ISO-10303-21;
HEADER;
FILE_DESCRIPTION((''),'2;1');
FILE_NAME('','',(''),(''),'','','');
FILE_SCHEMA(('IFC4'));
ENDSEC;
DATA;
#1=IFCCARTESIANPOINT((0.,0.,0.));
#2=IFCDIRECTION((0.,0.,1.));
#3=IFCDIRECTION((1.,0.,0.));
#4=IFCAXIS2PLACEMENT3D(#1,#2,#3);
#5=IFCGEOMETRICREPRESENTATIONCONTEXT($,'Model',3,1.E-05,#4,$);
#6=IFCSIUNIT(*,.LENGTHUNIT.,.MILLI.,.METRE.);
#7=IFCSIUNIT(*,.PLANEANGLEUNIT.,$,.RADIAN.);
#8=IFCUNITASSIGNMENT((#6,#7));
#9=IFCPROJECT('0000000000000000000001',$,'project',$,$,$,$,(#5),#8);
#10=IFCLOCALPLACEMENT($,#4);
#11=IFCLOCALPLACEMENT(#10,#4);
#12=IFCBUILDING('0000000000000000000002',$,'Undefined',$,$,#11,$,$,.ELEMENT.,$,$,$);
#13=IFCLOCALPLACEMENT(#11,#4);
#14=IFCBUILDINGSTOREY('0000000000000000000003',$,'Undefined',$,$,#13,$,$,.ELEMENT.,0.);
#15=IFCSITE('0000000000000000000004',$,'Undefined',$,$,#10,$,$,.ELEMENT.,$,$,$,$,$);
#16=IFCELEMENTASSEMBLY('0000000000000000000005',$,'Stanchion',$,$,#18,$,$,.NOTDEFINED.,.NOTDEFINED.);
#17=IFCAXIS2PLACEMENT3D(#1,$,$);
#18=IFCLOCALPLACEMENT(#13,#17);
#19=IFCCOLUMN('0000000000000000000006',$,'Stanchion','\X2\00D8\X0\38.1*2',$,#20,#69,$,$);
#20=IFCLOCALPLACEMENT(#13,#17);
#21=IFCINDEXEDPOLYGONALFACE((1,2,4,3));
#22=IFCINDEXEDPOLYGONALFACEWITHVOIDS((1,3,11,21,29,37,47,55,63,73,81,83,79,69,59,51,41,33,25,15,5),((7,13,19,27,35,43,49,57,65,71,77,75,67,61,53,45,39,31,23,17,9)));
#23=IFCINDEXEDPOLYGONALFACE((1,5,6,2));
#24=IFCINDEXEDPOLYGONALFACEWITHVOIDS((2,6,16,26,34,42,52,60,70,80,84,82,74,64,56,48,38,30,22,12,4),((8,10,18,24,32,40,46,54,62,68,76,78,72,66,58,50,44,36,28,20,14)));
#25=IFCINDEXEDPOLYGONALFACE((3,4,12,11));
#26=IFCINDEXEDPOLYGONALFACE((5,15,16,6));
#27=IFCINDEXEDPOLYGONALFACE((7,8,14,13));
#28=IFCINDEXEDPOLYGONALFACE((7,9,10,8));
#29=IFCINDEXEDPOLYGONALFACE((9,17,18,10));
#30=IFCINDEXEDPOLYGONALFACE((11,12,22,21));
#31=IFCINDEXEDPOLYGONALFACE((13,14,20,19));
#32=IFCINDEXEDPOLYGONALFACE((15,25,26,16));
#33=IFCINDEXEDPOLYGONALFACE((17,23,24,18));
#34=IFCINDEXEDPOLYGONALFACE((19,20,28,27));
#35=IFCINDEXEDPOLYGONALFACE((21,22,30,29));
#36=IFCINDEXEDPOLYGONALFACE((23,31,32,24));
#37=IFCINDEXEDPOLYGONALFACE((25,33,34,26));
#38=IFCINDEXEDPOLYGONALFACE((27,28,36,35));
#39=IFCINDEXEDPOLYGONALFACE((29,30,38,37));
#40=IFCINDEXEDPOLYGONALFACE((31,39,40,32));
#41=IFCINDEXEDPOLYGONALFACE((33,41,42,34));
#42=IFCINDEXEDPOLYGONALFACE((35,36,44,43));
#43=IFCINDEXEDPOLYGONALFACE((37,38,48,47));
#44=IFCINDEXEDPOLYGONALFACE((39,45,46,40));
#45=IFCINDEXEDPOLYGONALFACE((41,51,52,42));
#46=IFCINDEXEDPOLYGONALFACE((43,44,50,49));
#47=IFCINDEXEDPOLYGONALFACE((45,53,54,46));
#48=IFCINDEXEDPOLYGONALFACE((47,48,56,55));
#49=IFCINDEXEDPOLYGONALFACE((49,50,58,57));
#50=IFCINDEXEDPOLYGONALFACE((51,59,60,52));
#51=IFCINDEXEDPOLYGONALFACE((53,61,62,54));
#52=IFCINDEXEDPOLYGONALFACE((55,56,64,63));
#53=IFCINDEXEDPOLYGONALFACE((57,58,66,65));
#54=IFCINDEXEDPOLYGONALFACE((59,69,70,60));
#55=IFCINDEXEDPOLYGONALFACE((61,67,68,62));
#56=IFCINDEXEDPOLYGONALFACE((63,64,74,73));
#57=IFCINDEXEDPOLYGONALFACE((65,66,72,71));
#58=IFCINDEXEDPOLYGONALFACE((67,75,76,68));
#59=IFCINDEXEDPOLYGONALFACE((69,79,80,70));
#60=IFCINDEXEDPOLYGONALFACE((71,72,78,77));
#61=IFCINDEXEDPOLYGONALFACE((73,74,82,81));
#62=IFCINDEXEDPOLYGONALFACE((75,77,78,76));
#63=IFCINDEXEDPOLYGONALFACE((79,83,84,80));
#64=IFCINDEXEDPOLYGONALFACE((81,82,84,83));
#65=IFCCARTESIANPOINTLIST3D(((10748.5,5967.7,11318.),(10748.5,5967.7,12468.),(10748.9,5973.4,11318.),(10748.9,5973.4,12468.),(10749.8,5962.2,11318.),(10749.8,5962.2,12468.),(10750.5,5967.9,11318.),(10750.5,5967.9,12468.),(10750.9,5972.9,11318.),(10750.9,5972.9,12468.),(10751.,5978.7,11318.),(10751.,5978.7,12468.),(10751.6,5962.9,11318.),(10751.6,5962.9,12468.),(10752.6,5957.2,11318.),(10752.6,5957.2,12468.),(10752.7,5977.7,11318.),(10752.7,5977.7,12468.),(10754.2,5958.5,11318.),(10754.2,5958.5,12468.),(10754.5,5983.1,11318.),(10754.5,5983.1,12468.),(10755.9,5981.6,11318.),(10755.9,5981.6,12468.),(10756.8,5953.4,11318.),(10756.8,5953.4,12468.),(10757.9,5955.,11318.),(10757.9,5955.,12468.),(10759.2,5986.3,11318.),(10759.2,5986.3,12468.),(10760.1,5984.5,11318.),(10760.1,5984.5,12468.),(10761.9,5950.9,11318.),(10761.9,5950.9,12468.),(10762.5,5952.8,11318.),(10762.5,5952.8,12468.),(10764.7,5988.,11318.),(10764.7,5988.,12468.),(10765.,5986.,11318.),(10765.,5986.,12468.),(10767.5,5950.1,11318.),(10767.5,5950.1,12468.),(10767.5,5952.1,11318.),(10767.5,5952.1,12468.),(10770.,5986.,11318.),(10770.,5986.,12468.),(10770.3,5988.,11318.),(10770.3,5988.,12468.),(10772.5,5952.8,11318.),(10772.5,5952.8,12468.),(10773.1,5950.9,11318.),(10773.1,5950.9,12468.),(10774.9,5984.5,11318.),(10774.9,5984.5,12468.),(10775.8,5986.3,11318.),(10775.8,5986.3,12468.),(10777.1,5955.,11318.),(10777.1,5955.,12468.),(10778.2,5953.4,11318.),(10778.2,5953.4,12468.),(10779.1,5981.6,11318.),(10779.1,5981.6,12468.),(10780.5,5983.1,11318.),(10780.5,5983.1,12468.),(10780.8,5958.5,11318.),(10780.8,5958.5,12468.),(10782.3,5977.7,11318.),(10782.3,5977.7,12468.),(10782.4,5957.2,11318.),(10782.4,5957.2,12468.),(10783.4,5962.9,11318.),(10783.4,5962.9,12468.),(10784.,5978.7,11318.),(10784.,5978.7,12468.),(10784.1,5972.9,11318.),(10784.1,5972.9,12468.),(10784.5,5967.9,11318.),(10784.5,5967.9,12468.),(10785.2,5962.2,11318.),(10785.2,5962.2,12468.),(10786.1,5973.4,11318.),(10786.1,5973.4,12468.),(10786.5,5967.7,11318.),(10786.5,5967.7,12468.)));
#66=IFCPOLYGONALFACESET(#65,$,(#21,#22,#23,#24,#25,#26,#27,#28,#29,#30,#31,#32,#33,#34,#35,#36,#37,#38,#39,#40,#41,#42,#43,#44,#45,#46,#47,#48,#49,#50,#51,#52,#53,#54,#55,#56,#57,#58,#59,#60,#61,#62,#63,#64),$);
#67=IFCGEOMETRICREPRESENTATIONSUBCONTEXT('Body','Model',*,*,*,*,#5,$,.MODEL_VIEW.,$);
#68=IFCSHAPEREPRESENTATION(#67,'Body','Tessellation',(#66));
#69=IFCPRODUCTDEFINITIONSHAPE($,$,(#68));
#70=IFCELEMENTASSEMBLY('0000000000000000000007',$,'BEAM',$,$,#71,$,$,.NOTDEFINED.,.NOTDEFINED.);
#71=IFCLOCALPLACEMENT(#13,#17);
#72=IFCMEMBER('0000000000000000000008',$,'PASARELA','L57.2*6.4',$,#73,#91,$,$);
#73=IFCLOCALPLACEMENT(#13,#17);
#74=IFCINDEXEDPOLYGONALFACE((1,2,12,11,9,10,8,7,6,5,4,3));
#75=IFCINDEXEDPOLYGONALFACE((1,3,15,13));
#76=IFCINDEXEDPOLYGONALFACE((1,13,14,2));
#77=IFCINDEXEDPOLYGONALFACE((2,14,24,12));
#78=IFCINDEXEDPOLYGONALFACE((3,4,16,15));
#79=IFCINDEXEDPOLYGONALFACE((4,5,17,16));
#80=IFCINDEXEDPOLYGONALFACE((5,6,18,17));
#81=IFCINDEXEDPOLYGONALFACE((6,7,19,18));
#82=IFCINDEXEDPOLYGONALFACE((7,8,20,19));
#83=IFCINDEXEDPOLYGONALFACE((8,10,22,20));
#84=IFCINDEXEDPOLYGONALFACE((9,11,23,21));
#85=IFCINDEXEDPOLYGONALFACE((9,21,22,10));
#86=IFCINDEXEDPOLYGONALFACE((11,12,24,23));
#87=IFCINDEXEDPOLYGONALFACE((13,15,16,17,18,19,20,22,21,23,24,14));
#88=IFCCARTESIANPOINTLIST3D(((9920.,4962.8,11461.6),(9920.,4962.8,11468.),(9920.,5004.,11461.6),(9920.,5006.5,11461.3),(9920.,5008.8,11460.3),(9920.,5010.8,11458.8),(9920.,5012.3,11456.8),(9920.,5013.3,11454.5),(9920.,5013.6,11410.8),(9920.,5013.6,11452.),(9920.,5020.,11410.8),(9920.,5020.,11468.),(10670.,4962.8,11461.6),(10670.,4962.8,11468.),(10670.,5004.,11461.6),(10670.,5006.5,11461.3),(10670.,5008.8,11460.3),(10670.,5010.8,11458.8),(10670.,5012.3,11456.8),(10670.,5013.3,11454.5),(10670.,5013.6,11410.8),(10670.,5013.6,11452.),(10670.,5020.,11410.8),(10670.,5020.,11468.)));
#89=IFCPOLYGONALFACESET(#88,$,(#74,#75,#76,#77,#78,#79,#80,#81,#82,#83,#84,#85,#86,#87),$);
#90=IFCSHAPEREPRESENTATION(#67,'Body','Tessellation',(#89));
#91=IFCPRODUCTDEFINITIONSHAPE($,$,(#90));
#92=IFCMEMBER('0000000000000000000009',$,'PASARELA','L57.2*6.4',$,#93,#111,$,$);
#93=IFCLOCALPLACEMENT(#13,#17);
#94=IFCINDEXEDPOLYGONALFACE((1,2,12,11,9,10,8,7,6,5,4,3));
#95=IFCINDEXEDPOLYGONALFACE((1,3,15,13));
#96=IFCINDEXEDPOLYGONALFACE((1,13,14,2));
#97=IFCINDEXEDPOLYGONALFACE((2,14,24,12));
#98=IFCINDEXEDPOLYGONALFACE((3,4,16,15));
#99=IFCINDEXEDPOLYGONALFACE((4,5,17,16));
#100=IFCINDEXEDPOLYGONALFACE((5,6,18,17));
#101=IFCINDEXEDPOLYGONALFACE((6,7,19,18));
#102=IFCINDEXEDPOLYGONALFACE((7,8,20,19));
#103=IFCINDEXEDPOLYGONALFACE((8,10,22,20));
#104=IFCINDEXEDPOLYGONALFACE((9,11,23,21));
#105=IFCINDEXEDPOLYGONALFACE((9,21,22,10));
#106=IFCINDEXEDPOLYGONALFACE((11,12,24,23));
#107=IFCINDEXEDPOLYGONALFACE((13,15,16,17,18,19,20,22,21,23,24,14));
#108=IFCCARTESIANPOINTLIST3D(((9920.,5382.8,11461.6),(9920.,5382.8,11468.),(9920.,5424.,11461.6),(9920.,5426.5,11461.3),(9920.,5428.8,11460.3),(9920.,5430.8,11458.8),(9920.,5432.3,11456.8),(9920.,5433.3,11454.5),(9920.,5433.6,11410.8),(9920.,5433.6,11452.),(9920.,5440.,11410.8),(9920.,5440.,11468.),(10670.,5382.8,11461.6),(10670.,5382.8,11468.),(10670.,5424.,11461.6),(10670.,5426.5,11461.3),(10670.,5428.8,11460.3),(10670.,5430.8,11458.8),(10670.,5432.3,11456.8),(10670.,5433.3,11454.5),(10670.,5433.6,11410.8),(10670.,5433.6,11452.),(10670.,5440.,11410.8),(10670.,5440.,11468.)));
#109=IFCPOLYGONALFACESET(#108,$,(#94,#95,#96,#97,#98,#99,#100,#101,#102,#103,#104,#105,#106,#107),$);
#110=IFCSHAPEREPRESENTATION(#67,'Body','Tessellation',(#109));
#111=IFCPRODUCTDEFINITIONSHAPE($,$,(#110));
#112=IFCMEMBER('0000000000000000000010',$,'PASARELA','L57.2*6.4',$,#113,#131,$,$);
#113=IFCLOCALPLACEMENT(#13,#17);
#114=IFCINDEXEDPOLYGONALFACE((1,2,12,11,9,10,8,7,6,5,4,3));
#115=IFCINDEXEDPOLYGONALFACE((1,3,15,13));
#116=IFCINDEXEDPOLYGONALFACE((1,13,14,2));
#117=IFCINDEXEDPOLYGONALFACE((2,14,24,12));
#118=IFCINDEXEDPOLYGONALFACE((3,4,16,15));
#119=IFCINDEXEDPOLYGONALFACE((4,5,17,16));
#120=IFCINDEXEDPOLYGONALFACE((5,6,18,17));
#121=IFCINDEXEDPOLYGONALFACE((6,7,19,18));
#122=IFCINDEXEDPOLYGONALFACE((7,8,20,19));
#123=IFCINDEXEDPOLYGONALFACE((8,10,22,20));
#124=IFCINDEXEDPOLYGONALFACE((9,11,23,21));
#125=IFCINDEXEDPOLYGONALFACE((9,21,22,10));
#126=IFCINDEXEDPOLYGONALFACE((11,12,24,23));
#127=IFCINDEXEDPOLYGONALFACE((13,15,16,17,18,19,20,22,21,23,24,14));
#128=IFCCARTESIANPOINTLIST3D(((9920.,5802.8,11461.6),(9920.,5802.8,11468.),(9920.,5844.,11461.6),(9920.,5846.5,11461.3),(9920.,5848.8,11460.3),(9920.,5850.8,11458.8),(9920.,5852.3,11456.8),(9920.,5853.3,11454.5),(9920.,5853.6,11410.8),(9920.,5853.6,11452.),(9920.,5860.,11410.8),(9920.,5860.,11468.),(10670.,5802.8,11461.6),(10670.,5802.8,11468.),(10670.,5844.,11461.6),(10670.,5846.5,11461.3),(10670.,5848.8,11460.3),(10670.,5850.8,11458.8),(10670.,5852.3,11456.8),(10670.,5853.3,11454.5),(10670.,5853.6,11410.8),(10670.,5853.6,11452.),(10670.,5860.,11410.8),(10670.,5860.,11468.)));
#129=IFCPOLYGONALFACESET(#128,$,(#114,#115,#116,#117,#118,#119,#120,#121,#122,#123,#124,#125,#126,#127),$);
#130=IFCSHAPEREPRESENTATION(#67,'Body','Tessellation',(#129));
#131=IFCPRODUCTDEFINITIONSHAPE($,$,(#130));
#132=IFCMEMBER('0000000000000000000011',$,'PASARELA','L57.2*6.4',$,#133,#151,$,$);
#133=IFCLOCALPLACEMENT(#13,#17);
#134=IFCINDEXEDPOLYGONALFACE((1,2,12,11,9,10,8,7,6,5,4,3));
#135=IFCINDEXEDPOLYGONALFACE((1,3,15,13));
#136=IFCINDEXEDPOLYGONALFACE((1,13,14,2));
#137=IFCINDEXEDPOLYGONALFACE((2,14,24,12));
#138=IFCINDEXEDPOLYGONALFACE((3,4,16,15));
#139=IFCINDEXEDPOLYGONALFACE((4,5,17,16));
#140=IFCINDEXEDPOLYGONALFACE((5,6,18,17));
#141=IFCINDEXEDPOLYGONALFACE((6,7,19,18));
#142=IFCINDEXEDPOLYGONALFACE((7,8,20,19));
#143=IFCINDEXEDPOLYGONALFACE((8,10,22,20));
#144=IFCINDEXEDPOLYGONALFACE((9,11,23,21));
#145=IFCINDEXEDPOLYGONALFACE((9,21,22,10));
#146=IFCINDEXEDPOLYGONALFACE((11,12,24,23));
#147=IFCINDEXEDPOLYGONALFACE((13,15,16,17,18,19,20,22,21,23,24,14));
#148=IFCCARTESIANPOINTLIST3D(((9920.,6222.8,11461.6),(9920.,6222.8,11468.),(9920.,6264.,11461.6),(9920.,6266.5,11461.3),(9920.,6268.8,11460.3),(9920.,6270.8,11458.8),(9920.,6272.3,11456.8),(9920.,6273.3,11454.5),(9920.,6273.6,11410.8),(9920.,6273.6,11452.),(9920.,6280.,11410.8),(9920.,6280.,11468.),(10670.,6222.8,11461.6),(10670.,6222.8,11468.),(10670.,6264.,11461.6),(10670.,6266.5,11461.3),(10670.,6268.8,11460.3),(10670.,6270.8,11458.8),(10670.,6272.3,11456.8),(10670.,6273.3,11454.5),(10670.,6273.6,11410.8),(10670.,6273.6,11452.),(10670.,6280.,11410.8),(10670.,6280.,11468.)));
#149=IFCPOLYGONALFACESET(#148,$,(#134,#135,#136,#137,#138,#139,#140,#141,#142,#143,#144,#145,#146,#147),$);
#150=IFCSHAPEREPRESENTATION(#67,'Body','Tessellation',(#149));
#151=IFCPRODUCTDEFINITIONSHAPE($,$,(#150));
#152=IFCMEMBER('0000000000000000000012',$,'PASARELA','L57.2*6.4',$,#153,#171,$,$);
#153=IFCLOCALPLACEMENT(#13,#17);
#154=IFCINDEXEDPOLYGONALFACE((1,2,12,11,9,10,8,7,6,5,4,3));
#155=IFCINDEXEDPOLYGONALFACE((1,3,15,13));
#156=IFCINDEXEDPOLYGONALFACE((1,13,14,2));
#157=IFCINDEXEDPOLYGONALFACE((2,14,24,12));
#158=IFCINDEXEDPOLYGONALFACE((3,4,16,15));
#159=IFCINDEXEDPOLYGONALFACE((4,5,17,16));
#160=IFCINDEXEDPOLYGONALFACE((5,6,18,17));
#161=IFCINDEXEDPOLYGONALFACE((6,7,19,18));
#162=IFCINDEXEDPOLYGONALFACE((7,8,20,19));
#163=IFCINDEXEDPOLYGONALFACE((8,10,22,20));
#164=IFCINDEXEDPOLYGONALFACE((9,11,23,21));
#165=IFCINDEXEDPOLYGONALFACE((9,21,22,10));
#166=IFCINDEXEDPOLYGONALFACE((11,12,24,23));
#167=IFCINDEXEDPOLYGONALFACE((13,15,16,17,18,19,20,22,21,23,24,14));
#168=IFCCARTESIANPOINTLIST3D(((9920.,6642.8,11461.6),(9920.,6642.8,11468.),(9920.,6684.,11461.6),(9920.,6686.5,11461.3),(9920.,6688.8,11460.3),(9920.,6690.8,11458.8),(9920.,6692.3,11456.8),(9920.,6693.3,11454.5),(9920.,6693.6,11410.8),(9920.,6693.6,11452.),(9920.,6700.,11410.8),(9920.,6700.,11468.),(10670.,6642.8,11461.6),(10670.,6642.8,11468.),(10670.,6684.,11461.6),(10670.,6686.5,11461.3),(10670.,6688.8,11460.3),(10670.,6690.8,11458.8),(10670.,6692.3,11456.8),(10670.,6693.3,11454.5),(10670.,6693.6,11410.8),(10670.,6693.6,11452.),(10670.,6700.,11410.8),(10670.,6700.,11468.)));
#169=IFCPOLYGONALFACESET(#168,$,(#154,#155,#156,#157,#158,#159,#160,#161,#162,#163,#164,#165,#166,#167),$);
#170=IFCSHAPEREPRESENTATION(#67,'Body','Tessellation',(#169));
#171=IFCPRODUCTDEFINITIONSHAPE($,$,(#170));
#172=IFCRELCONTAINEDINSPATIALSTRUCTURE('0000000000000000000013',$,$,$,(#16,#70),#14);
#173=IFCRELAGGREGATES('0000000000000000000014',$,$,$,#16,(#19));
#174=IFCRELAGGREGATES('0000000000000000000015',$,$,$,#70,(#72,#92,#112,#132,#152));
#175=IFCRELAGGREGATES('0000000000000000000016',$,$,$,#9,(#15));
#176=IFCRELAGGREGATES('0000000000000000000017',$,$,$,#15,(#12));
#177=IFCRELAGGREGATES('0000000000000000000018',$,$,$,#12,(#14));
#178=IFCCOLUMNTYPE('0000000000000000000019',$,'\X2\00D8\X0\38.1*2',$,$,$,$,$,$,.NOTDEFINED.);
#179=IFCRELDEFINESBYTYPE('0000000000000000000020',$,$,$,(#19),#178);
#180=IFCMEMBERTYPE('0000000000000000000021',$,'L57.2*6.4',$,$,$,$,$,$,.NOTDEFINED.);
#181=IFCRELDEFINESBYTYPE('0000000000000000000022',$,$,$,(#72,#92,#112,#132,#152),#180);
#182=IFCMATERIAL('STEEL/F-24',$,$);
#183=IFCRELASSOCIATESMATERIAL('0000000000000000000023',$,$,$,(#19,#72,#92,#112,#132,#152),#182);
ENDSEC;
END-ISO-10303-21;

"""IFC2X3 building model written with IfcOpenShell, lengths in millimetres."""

from ifc_helpers import new_model, si_unit, frame, origin_with_axes, origin_2d_with_axis, place, context, subcontext, project, spatial, hollow_circle, l_section, extrude, material, type_object, element, aggregate, save


model = new_model("IFC2X3")

# Units and contexts
model_context = context("Model", 3, precision=1e-05, world=origin_with_axes())
body_context = subcontext(model_context, "Body", "Model", "MODEL_VIEW")
ifc_project = project(units=[si_unit("LENGTHUNIT", "METRE", prefix="MILLI"), si_unit("PLANEANGLEUNIT", "RADIAN")], contexts=[model_context])

# Site, building, storey
site_placement = place(None, origin_with_axes())
site = spatial("IfcSite", under=ifc_project, at=site_placement, Name="Undefined", CompositionType="ELEMENT")
building_placement = place(site_placement, origin_with_axes())
building = spatial("IfcBuilding", under=site, at=building_placement, Name="Undefined", CompositionType="ELEMENT")
storey_placement = place(building_placement, origin_with_axes())
storey = spatial("IfcBuildingStorey", under=building, at=storey_placement, Name="Undefined", CompositionType="ELEMENT", Elevation=0.0)

# Element assembly, column
ifc_material_1 = material(Name="STEEL/F-24")
column_type = type_object("IfcColumnType", Name="Ø38.1*2", PredefinedType="NOTDEFINED")
assembly_1_placement = place(storey_placement, origin_with_axes())
assembly_1 = element("IfcElementAssembly", 1, at=assembly_1_placement, inside=storey, Name="Stanchion", AssemblyPlace="NOTDEFINED", PredefinedType="NOTDEFINED")
column_1_placement = place(assembly_1_placement, frame((10767.5, 5969.1, 11318.0), z_axis=(0.0, 0.0, 1.0), x_axis=(-1.0, 0.0, 0.0)))
column_1 = element("IfcColumn", 2, at=column_1_placement, type_object=column_type, material=ifc_material_1, Name="Stanchion", Description="Ø38.1*2", context=body_context, shape_type="SweptSolid", body=[
    extrude(hollow_circle(Radius=19.1, WallThickness=2.0, at=origin_2d_with_axis()), frame((0.0, 0.0, 1150.0), z_axis=(0.0, 0.0, -1.0), x_axis=(0.0, 1.0, 0.0)), (0.0, 0.0, 1.0), 1150.0),
])

# Element assembly, members
assembly_2_placement = place(storey_placement, origin_with_axes())
assembly_2 = element("IfcElementAssembly", 3, at=assembly_2_placement, inside=storey, Name="BEAM", AssemblyPlace="NOTDEFINED", PredefinedType="NOTDEFINED")
member_type = type_object("IfcMemberType", Name="L57.2*6.4", PredefinedType="NOTDEFINED")
member_1_placement = place(assembly_2_placement, frame((10670.0, 4991.4, 11439.4), z_axis=(0.0, 0.0, -1.0), x_axis=(-1.0, 0.0, 0.0)))
member_1 = element("IfcMember", 4, at=member_1_placement, type_object=member_type, material=ifc_material_1, Name="PASARELA", Description="L57.2*6.4", context=body_context, shape_type="SweptSolid", body=[
    extrude(l_section(Depth=57.2, Width=57.2, Thickness=6.4, FilletRadius=9.6, at=origin_2d_with_axis()), frame((750.0, 0.0, 0.0), z_axis=(-1.0, 0.0, 0.0), x_axis=(0.0, -1.0, 0.0)), (0.0, 0.0, 1.0), 750.0),
])
member_2_placement = place(assembly_2_placement, frame((10670.0, 5411.4, 11439.4), z_axis=(0.0, 0.0, -1.0), x_axis=(-1.0, 0.0, 0.0)))
member_2 = element("IfcMember", 5, at=member_2_placement, type_object=member_type, material=ifc_material_1, Name="PASARELA", Description="L57.2*6.4", context=body_context, shape_type="SweptSolid", body=[
    extrude(l_section(Depth=57.2, Width=57.2, Thickness=6.4, FilletRadius=9.6, at=origin_2d_with_axis()), frame((750.0, 0.0, 0.0), z_axis=(-1.0, 0.0, 0.0), x_axis=(0.0, -1.0, 0.0)), (0.0, 0.0, 1.0), 750.0),
])
member_3_placement = place(assembly_2_placement, frame((10670.0, 5831.4, 11439.4), z_axis=(0.0, 0.0, -1.0), x_axis=(-1.0, 0.0, 0.0)))
member_3 = element("IfcMember", 6, at=member_3_placement, type_object=member_type, material=ifc_material_1, Name="PASARELA", Description="L57.2*6.4", context=body_context, shape_type="SweptSolid", body=[
    extrude(l_section(Depth=57.2, Width=57.2, Thickness=6.4, FilletRadius=9.6, at=origin_2d_with_axis()), frame((750.0, 0.0, 0.0), z_axis=(-1.0, 0.0, 0.0), x_axis=(0.0, -1.0, 0.0)), (0.0, 0.0, 1.0), 750.0),
])
member_4_placement = place(assembly_2_placement, frame((10670.0, 6251.4, 11439.4), z_axis=(0.0, 0.0, -1.0), x_axis=(-1.0, 0.0, 0.0)))
member_4 = element("IfcMember", 7, at=member_4_placement, type_object=member_type, material=ifc_material_1, Name="PASARELA", Description="L57.2*6.4", context=body_context, shape_type="SweptSolid", body=[
    extrude(l_section(Depth=57.2, Width=57.2, Thickness=6.4, FilletRadius=9.6, at=origin_2d_with_axis()), frame((750.0, 0.0, 0.0), z_axis=(-1.0, 0.0, 0.0), x_axis=(0.0, -1.0, 0.0)), (0.0, 0.0, 1.0), 750.0),
])
member_5_placement = place(assembly_2_placement, frame((10670.0, 6671.4, 11439.4), z_axis=(0.0, 0.0, -1.0), x_axis=(-1.0, 0.0, 0.0)))
member_5 = element("IfcMember", 8, at=member_5_placement, type_object=member_type, material=ifc_material_1, Name="PASARELA", Description="L57.2*6.4", context=body_context, shape_type="SweptSolid", body=[
    extrude(l_section(Depth=57.2, Width=57.2, Thickness=6.4, FilletRadius=9.6, at=origin_2d_with_axis()), frame((750.0, 0.0, 0.0), z_axis=(-1.0, 0.0, 0.0), x_axis=(0.0, -1.0, 0.0)), (0.0, 0.0, 1.0), 750.0),
])

aggregate(assembly_1, [column_1])

aggregate(assembly_2, [member_1, member_2, member_3, member_4, member_5])

save(model, "model.ifc")
